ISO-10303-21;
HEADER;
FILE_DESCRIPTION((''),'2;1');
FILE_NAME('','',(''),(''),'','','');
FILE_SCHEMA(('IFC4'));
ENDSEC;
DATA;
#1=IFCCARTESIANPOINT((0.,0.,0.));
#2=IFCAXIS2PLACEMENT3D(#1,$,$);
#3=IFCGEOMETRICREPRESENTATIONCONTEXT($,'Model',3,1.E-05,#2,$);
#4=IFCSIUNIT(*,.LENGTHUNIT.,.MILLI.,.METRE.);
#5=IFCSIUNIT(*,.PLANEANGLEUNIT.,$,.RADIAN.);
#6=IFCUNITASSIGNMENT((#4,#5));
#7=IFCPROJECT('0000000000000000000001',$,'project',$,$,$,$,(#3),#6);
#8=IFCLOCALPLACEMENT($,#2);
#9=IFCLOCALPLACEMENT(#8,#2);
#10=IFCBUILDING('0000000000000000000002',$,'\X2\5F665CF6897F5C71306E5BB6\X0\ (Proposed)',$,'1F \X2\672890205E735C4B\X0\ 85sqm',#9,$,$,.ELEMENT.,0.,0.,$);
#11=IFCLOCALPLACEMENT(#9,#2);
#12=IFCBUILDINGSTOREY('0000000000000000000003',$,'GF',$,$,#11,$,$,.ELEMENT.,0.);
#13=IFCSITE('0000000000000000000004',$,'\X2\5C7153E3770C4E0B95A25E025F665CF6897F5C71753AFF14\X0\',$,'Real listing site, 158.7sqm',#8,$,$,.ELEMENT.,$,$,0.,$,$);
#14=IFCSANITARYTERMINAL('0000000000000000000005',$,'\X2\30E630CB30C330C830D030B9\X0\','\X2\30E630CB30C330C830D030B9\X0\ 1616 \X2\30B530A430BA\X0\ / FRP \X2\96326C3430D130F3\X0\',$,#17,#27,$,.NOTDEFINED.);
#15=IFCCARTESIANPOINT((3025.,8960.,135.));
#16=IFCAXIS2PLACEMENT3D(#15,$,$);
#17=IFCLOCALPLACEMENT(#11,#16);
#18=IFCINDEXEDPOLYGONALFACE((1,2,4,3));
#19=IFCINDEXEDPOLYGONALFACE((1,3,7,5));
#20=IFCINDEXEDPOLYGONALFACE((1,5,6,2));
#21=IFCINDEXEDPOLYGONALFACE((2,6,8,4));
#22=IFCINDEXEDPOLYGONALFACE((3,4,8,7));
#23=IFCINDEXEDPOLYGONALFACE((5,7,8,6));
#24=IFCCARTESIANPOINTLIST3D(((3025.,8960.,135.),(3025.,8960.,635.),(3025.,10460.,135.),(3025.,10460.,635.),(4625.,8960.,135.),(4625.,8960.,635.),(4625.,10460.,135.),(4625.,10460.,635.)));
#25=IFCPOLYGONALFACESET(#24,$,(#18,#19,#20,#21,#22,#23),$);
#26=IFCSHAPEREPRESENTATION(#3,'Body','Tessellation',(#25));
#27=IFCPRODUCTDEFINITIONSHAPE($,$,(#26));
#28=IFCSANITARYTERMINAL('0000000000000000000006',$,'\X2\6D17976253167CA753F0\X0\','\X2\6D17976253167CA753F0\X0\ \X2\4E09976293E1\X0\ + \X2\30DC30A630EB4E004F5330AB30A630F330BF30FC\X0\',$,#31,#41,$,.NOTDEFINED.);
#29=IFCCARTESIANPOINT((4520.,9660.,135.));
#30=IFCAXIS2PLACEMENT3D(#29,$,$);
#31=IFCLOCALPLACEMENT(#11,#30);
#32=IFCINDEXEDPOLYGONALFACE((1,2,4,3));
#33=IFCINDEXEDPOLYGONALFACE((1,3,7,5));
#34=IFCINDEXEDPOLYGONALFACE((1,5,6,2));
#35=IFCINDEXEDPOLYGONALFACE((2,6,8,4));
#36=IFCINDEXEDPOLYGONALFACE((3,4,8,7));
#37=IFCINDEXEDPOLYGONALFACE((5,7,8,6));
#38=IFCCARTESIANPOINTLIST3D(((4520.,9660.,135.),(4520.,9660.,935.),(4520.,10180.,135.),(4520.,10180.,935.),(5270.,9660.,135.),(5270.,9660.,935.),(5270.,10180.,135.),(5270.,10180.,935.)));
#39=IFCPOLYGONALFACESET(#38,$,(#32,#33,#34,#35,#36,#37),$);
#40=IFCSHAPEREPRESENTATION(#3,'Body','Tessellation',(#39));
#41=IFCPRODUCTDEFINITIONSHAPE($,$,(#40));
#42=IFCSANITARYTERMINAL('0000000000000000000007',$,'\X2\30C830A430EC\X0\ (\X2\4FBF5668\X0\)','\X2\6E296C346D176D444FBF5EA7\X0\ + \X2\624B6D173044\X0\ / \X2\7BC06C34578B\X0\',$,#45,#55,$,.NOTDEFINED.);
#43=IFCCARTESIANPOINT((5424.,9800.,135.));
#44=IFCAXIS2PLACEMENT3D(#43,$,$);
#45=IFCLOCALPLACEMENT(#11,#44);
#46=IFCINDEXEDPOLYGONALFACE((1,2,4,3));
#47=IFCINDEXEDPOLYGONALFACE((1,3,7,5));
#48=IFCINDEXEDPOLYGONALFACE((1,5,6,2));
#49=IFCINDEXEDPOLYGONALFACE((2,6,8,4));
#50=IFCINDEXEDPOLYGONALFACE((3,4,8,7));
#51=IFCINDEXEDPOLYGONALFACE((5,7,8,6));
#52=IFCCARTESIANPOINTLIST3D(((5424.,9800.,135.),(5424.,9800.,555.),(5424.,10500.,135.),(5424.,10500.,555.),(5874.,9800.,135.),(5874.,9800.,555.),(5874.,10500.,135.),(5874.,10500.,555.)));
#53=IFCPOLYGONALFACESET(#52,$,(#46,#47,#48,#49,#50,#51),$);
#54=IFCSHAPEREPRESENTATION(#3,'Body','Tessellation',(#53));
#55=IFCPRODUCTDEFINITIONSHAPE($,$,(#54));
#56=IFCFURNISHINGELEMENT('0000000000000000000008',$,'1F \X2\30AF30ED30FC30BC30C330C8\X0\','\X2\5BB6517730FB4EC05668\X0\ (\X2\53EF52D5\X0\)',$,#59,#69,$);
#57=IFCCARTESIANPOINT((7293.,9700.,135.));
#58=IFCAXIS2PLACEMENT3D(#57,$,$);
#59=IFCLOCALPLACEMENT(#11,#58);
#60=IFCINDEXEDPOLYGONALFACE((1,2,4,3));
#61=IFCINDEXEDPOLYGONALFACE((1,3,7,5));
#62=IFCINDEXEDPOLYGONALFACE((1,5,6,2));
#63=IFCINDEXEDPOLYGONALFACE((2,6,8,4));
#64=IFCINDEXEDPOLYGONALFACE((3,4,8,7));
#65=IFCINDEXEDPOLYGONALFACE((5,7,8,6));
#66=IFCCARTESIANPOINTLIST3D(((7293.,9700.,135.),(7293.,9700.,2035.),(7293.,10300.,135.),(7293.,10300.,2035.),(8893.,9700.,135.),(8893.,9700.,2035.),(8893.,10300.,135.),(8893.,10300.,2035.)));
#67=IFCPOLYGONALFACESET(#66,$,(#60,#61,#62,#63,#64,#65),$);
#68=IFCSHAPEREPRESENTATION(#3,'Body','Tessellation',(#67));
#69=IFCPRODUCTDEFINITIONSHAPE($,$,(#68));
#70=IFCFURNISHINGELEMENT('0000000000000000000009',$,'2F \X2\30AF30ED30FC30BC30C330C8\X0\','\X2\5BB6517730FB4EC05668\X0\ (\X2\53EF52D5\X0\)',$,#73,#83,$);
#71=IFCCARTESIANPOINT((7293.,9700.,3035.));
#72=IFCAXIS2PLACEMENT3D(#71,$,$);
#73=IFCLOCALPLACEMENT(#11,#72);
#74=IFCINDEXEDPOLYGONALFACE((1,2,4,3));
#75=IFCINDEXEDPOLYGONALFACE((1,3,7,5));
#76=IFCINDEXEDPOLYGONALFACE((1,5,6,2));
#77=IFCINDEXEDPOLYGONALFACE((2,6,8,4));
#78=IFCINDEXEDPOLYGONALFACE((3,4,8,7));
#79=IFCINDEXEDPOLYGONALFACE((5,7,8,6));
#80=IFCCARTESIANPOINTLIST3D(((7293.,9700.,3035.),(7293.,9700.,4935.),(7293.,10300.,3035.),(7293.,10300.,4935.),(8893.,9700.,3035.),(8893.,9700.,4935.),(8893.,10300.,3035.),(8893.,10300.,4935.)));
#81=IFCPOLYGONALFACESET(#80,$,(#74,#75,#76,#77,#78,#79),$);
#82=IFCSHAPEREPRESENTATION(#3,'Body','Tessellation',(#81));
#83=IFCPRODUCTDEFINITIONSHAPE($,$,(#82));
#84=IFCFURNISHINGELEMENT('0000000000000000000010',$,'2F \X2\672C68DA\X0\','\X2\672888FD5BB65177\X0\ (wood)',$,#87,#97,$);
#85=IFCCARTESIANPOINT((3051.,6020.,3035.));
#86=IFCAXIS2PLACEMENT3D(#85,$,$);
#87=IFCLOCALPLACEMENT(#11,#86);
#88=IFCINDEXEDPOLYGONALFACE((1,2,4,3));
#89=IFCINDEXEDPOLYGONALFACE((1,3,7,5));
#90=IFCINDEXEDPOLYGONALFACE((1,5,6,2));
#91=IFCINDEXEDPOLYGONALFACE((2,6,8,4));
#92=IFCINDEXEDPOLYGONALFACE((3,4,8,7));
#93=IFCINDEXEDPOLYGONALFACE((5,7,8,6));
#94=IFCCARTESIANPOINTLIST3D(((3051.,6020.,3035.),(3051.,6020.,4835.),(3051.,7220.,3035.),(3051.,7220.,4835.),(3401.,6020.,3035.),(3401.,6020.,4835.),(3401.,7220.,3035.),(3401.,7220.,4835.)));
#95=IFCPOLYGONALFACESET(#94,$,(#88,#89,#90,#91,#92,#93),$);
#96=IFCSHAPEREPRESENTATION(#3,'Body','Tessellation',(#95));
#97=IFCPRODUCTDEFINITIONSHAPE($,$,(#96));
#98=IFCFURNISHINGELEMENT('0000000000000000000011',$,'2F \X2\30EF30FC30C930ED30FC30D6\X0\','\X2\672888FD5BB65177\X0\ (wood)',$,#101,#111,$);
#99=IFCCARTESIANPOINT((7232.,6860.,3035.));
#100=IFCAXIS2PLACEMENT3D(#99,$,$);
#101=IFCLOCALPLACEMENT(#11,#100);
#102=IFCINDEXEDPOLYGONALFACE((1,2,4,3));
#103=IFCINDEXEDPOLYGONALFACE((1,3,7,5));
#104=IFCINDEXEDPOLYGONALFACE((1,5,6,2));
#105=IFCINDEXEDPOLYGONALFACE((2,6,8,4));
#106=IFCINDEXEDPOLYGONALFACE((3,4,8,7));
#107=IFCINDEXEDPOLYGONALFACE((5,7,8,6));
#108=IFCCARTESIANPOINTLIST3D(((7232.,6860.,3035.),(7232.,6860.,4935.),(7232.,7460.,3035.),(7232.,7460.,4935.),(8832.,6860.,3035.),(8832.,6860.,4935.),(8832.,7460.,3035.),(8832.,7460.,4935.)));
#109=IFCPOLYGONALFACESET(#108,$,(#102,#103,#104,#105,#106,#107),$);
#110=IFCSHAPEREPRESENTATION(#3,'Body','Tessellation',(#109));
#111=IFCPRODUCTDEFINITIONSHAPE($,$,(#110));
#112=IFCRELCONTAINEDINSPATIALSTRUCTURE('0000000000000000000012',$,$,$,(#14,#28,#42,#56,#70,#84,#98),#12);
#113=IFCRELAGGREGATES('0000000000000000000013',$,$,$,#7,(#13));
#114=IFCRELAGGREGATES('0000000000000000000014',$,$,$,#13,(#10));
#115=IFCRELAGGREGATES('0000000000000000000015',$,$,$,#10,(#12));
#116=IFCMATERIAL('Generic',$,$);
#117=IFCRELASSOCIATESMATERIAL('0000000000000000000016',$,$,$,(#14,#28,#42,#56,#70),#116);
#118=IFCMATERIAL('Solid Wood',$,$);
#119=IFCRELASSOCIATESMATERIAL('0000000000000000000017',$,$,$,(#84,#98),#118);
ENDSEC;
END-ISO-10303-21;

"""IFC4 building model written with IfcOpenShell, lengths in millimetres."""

from ifc_helpers import new_model, si_unit, frame, frame_2d, origin, place, context, project, spatial, rectangle, extrude, material, element, save


model = new_model("IFC4")

# Units and contexts
model_context = context("Model", 3, precision=1e-05, world=origin())
ifc_project = project(units=[si_unit("LENGTHUNIT", "METRE", prefix="MILLI"), si_unit("PLANEANGLEUNIT", "RADIAN")], contexts=[model_context])

# Site, building, storey
site_placement = place(None, origin())
site = spatial("IfcSite", under=ifc_project, at=site_placement, Name="山口県下関市彦島西山町４", ObjectType="Real listing site, 158.7sqm", CompositionType="ELEMENT", RefElevation=0.0)
building_placement = place(site_placement, origin())
building = spatial("IfcBuilding", under=site, at=building_placement, Name="彦島西山の家 (Proposed)", ObjectType="1F 木造平屋 85sqm", CompositionType="ELEMENT", ElevationOfRefHeight=0.0, ElevationOfTerrain=0.0)
storey_placement = place(building_placement, origin())
storey = spatial("IfcBuildingStorey", under=building, at=storey_placement, Name="GF", CompositionType="ELEMENT", Elevation=0.0)

# Shared definitions
ifc_material_1 = material(Name="Solid Wood")

# Shared definitions
ifc_material_2 = material(Name="Generic")

# Sanitary terminals
sanitary_terminal_1_placement = place(storey_placement, frame((3025.0, 8960.0, 135.0)))
element("IfcSanitaryTerminal", 1, at=sanitary_terminal_1_placement, inside=storey, material=ifc_material_2, Name="ユニットバス", Description="ユニットバス 1616 サイズ / FRP 防水パン", PredefinedType="NOTDEFINED", context=model_context, shape_type="SweptSolid", body=[
    extrude(rectangle(XDim=1600.0, YDim=1500.0, at=frame_2d((800.0, 750.0))), frame((3025.0, 8960.0, 135.0)), (0.0, 0.0, 1.0), 500.0),
])
sanitary_terminal_2_placement = place(storey_placement, frame((4520.0, 9660.0, 135.0)))
element("IfcSanitaryTerminal", 2, at=sanitary_terminal_2_placement, inside=storey, material=ifc_material_2, Name="洗面化粧台", Description="洗面化粧台 三面鏡 + ボウル一体カウンター", PredefinedType="NOTDEFINED", context=model_context, shape_type="SweptSolid", body=[
    extrude(rectangle(XDim=750.0, YDim=520.0, at=frame_2d((375.0, 260.0))), frame((4520.0, 9660.0, 135.0)), (0.0, 0.0, 1.0), 800.0),
])
sanitary_terminal_3_placement = place(storey_placement, frame((5424.0, 9800.0, 135.0)))
element("IfcSanitaryTerminal", 3, at=sanitary_terminal_3_placement, inside=storey, material=ifc_material_2, Name="トイレ (便器)", Description="温水洗浄便座 + 手洗い / 節水型", PredefinedType="NOTDEFINED", context=model_context, shape_type="SweptSolid", body=[
    extrude(rectangle(XDim=450.0, YDim=700.0, at=frame_2d((225.0, 350.0))), frame((5424.0, 9800.0, 135.0)), (0.0, 0.0, 1.0), 420.0),
])

# Furnishing elements
furnishing_1_placement = place(storey_placement, frame((7293.0, 9700.0, 135.0)))
element("IfcFurnishingElement", 4, at=furnishing_1_placement, inside=storey, material=ifc_material_2, Name="1F クローゼット", Description="家具・什器 (可動)", context=model_context, shape_type="SweptSolid", body=[
    extrude(rectangle(XDim=1600.0, YDim=600.0, at=frame_2d((800.0, 300.0))), frame((7293.0, 9700.0, 135.0)), (0.0, 0.0, 1.0), 1900.0),
])
furnishing_2_placement = place(storey_placement, frame((7293.0, 9700.0, 3035.0)))
element("IfcFurnishingElement", 5, at=furnishing_2_placement, inside=storey, material=ifc_material_2, Name="2F クローゼット", Description="家具・什器 (可動)", context=model_context, shape_type="SweptSolid", body=[
    extrude(rectangle(XDim=1600.0, YDim=600.0, at=frame_2d((800.0, 300.0))), frame((7293.0, 9700.0, 3035.0)), (0.0, 0.0, 1.0), 1900.0),
])
furnishing_3_placement = place(storey_placement, frame((3051.0, 6020.0, 3035.0)))
element("IfcFurnishingElement", 6, at=furnishing_3_placement, inside=storey, material=ifc_material_1, Name="2F 本棚", Description="木製家具 (wood)", context=model_context, shape_type="SweptSolid", body=[
    extrude(rectangle(XDim=350.0, YDim=1200.0, at=frame_2d((175.0, 600.0))), frame((3051.0, 6020.0, 3035.0)), (0.0, 0.0, 1.0), 1800.0),
])
furnishing_4_placement = place(storey_placement, frame((7232.0, 6860.0, 3035.0)))
element("IfcFurnishingElement", 7, at=furnishing_4_placement, inside=storey, material=ifc_material_1, Name="2F ワードローブ", Description="木製家具 (wood)", context=model_context, shape_type="SweptSolid", body=[
    extrude(rectangle(XDim=1600.0, YDim=600.0, at=frame_2d((800.0, 300.0))), frame((7232.0, 6860.0, 3035.0)), (0.0, 0.0, 1.0), 1900.0),
])

save(model, "model.ifc")
